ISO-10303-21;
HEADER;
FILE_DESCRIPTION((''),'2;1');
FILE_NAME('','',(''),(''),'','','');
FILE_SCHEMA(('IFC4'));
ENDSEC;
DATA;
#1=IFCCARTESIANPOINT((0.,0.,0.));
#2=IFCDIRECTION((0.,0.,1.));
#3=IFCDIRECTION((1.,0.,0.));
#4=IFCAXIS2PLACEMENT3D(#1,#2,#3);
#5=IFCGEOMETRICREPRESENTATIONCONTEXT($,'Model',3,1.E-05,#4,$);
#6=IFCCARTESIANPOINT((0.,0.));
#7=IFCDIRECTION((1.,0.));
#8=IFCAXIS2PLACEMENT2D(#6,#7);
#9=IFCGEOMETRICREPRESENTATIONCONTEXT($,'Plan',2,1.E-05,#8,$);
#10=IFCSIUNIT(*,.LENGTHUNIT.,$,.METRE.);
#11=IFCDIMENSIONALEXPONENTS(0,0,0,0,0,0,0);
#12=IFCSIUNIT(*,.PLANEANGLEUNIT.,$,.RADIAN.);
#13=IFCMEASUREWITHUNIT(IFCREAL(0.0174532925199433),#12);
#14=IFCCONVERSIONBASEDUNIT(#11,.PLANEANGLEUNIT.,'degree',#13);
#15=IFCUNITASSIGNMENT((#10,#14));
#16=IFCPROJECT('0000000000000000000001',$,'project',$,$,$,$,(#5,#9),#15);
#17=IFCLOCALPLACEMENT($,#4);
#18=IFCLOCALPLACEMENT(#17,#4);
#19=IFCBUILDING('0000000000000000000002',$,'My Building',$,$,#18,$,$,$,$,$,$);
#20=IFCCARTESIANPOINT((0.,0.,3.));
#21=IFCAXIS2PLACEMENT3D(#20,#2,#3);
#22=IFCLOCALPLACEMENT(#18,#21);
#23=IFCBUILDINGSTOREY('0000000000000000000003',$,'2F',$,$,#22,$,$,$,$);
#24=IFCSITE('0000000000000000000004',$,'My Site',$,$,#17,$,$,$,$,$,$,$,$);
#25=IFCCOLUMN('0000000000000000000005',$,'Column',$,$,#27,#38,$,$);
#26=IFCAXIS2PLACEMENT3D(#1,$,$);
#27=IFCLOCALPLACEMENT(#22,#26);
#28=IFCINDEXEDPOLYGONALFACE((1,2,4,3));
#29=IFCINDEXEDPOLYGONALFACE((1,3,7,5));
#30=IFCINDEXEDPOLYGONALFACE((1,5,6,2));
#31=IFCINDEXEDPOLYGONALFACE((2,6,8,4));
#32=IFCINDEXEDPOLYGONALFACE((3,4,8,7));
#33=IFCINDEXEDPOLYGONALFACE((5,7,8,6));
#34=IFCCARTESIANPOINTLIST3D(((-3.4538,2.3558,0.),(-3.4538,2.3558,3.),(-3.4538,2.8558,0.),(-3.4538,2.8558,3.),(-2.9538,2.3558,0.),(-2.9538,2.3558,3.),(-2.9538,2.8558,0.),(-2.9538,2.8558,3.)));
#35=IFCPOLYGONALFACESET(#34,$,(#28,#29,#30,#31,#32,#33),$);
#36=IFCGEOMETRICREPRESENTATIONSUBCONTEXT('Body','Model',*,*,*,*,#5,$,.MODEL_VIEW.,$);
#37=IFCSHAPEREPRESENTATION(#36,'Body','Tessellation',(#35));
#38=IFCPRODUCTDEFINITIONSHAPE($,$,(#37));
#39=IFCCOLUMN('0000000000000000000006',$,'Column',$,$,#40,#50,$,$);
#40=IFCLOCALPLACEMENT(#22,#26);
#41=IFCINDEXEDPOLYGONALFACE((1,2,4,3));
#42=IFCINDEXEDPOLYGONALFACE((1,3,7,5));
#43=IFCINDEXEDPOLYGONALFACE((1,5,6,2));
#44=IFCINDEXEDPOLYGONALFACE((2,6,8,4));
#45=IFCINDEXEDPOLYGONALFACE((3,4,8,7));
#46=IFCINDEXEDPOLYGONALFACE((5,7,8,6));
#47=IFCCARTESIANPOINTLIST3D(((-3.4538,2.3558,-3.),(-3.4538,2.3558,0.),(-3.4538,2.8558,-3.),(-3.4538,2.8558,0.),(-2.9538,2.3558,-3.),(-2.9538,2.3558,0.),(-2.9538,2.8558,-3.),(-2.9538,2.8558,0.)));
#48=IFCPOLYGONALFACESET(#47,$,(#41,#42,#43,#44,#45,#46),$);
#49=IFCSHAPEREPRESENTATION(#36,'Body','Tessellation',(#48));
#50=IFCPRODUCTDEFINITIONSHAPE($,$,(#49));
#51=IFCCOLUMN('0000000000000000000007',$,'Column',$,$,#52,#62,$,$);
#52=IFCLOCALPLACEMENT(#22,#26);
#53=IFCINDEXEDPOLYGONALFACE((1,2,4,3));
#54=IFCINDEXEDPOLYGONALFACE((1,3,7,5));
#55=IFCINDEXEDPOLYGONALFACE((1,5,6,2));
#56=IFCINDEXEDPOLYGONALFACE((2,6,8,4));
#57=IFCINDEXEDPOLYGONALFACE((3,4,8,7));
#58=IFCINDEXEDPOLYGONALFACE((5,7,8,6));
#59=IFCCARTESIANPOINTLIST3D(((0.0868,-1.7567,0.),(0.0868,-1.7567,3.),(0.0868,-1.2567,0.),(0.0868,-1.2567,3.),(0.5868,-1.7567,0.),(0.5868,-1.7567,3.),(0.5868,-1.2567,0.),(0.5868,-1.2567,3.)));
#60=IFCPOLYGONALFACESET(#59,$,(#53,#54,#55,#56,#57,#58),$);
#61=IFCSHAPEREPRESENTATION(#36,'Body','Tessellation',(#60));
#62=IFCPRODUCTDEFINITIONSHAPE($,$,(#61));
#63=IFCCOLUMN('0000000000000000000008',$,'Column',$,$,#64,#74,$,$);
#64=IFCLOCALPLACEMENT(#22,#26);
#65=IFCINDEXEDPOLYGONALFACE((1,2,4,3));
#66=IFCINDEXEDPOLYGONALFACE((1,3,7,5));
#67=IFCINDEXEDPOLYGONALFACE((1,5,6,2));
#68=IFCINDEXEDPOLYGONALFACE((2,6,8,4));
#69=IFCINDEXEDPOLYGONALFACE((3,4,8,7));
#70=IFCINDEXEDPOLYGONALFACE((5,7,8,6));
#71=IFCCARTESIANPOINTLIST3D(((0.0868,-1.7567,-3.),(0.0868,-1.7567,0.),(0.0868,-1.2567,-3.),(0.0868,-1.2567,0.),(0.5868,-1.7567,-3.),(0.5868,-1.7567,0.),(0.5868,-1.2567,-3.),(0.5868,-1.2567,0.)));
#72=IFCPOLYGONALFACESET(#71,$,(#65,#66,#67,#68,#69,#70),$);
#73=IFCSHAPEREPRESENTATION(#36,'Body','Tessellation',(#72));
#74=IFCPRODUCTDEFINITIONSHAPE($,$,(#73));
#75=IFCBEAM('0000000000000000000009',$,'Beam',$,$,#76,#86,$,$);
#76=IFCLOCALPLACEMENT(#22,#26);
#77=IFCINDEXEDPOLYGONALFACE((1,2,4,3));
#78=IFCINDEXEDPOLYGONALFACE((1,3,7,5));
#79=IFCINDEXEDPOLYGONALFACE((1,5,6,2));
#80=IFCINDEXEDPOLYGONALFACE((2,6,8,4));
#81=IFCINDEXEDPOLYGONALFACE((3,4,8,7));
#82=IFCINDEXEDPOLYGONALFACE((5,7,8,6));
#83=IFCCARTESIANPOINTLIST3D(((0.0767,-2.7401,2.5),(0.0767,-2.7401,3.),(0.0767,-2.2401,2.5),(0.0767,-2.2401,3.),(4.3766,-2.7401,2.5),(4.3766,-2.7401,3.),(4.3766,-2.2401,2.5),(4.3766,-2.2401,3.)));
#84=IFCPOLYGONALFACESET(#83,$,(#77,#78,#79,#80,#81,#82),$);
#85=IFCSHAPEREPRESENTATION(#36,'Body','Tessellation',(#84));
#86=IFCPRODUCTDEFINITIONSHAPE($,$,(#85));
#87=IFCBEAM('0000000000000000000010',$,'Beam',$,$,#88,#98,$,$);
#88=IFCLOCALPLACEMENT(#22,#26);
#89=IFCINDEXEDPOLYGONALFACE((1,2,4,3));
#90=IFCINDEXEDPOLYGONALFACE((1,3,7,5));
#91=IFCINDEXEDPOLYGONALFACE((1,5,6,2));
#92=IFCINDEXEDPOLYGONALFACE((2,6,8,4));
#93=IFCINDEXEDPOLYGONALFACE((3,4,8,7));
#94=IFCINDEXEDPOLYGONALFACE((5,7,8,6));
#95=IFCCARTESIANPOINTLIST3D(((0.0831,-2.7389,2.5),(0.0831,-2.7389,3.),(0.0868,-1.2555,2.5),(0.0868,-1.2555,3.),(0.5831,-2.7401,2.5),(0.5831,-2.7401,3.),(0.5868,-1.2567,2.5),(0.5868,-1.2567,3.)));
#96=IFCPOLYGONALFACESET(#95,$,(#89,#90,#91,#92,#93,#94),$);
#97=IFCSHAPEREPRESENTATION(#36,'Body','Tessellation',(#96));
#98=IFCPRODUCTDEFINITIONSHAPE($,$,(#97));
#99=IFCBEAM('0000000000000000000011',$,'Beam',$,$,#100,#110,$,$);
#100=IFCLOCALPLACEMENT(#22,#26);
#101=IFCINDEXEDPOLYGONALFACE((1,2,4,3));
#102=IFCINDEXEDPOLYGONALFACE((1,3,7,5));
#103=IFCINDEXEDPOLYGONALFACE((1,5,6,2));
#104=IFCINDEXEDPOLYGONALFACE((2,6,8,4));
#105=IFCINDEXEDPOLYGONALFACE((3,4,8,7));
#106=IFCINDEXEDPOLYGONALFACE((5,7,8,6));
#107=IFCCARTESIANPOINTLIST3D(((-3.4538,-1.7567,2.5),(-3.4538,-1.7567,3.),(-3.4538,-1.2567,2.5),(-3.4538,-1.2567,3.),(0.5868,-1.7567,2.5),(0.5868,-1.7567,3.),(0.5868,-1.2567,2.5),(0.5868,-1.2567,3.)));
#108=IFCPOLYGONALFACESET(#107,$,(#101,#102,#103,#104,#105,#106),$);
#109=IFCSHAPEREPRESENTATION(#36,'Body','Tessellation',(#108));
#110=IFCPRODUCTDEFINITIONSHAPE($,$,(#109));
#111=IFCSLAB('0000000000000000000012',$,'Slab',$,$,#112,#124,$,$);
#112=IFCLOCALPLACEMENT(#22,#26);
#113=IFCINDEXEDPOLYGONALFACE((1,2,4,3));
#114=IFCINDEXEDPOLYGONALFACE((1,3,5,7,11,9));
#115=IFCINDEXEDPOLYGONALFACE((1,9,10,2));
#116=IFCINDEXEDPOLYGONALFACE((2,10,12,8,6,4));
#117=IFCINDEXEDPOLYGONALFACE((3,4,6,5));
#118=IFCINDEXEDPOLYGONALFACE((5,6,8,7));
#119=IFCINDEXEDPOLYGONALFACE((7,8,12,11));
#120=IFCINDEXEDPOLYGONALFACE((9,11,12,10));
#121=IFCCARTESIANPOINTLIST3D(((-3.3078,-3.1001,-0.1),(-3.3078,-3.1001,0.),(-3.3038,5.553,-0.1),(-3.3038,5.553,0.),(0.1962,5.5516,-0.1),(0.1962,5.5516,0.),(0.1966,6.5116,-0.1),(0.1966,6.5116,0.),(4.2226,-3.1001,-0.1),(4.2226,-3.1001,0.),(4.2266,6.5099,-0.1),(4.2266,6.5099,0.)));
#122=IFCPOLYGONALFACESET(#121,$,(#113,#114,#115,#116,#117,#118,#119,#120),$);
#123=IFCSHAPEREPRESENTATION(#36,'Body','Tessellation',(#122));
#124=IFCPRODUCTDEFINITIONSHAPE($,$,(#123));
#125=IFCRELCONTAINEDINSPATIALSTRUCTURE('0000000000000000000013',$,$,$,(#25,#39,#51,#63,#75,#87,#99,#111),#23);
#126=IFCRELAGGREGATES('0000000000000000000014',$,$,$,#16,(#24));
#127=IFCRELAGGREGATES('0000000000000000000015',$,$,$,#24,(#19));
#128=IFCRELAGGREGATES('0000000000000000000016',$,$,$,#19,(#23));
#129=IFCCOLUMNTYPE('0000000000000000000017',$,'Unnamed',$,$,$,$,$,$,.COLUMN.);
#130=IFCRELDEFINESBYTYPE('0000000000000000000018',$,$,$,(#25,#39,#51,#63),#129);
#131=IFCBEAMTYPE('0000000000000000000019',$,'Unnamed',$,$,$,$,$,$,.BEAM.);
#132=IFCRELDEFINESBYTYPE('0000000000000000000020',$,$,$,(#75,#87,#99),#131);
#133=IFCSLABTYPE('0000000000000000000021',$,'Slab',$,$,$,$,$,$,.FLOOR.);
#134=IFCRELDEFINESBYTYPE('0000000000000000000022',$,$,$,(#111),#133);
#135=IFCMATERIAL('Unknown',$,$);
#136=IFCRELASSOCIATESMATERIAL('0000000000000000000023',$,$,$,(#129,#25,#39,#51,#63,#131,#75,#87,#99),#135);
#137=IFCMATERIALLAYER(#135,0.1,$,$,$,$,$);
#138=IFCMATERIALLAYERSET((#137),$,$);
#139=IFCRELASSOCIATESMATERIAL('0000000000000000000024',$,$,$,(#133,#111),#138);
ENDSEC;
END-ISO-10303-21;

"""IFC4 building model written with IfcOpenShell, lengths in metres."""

from ifc_helpers import new_model, entity, si_unit, converted_unit, frame, origin_with_axes, origin_2d_with_axis, place, context, subcontext, project, spatial, indexed_curve, rectangle, outline, extrude, material, layer, layer_set, layer_usage, material_profile, profile_set, profile_usage, type_object, element, save


model = new_model("IFC4")

# Units and contexts
model_context = context("Model", 3, precision=1e-05, world=origin_with_axes())
plan_context = context("Plan", 2, precision=1e-05, world=origin_2d_with_axis())
body_context_1 = subcontext(model_context, "Body", "Model", "MODEL_VIEW")
ifc_project = project(units=[si_unit("LENGTHUNIT", "METRE"), converted_unit("PLANEANGLEUNIT", "degree", entity("IfcReal", 0.0174532925199433), si_unit("PLANEANGLEUNIT", "RADIAN"), dimensions=[0, 0, 0, 0, 0, 0, 0])], contexts=[model_context, plan_context])

# Site, building, storey
site_placement = place(None, origin_with_axes())
site = spatial("IfcSite", under=ifc_project, at=site_placement, Name="My Site")
building_placement = place(site_placement, origin_with_axes())
building = spatial("IfcBuilding", under=site, at=building_placement, Name="My Building")
storey_placement = place(building_placement, frame((0.0, 0.0, 3.0), z_axis=(0.0, 0.0, 1.0), x_axis=(1.0, 0.0, 0.0)))
storey = spatial("IfcBuildingStorey", under=building, at=storey_placement, Name="2F")

# Columns
ifc_material = material(Name="Unknown")
ifc_material_profile_1 = material_profile(ifc_material, rectangle(XDim=0.5, YDim=0.5))
ifc_profile_set_1 = profile_set([ifc_material_profile_1])
ifc_profile_usage_1 = profile_usage(ifc_profile_set_1, cardinal=5)
column_type = type_object("IfcColumnType", Name="Unnamed", PredefinedType="COLUMN", material=ifc_profile_set_1)
column_1_placement = place(storey_placement, frame((-3.2038, 2.6058, 0.0), z_axis=(0.0, 0.0, 1.0), x_axis=(1.0, 0.0, 0.0)))
element("IfcColumn", 1, at=column_1_placement, inside=storey, type_object=column_type, material=ifc_profile_usage_1, Name="Column", context=body_context_1, shape_type="SweptSolid", body=[
    extrude(rectangle(XDim=0.5, YDim=0.5), origin_with_axes(), (0.0, 0.0, 1.0), 3.0),
])
ifc_profile_usage_2 = profile_usage(ifc_profile_set_1, cardinal=5)
column_2_placement = place(storey_placement, frame((-3.2038, 2.6058, -3.0), z_axis=(0.0, 0.0, 1.0), x_axis=(1.0, 0.0, 0.0)))
element("IfcColumn", 2, at=column_2_placement, inside=storey, type_object=column_type, material=ifc_profile_usage_2, Name="Column", context=body_context_1, shape_type="SweptSolid", body=[
    extrude(rectangle(XDim=0.5, YDim=0.5), origin_with_axes(), (0.0, 0.0, 1.0), 3.0),
])
ifc_profile_usage_3 = profile_usage(ifc_profile_set_1, cardinal=5)
column_3_placement = place(storey_placement, frame((0.3368, -1.5067, 0.0), z_axis=(0.0, 0.0, 1.0), x_axis=(1.0, 0.0, 0.0)))
element("IfcColumn", 3, at=column_3_placement, inside=storey, type_object=column_type, material=ifc_profile_usage_3, Name="Column", context=body_context_1, shape_type="SweptSolid", body=[
    extrude(rectangle(XDim=0.5, YDim=0.5), origin_with_axes(), (0.0, 0.0, 1.0), 3.0),
])
ifc_profile_usage_4 = profile_usage(ifc_profile_set_1, cardinal=5)
column_4_placement = place(storey_placement, frame((0.3368, -1.5067, -3.0), z_axis=(0.0, 0.0, 1.0), x_axis=(1.0, 0.0, 0.0)))
element("IfcColumn", 4, at=column_4_placement, inside=storey, type_object=column_type, material=ifc_profile_usage_4, Name="Column", context=body_context_1, shape_type="SweptSolid", body=[
    extrude(rectangle(XDim=0.5, YDim=0.5), origin_with_axes(), (0.0, 0.0, 1.0), 3.0),
])

# Beams
ifc_material_profile_2 = material_profile(ifc_material, rectangle(XDim=0.5, YDim=0.5))
ifc_profile_set_2 = profile_set([ifc_material_profile_2])
ifc_profile_usage_5 = profile_usage(ifc_profile_set_2, cardinal=7)
beam_type = type_object("IfcBeamType", Name="Unnamed", PredefinedType="BEAM", material=ifc_profile_set_2)
beam_1_placement = place(storey_placement, frame((0.0767, -2.2401, 3.0), z_axis=(1.0, 0.0, 0.0), x_axis=(0.0, 1.0, 0.0)))
element("IfcBeam", 5, at=beam_1_placement, inside=storey, type_object=beam_type, material=ifc_profile_usage_5, Name="Beam", context=body_context_1, shape_type="SweptSolid", body=[
    extrude(rectangle(XDim=0.5, YDim=0.5), frame((-0.25, -0.25, 0.0), z_axis=(0.0, 0.0, 1.0), x_axis=(1.0, 0.0, 0.0)), (0.0, 0.0, 1.0), 4.2999),
])
ifc_profile_usage_6 = profile_usage(ifc_profile_set_2, cardinal=7)
beam_2_placement = place(storey_placement, frame((0.5868, -1.2567, 3.0), z_axis=(-0.002444, -0.999997, 0.0), x_axis=(0.999997, -0.002444, 0.0)))
element("IfcBeam", 6, at=beam_2_placement, inside=storey, type_object=beam_type, material=ifc_profile_usage_6, Name="Beam", context=body_context_1, shape_type="SweptSolid", body=[
    extrude(rectangle(XDim=0.5, YDim=0.5), frame((-0.25, -0.25, 0.0), z_axis=(0.0, 0.0, 1.0), x_axis=(1.0, 0.0, 0.0)), (0.0, 0.0, 1.0), 1.4834),
])
ifc_profile_usage_7 = profile_usage(ifc_profile_set_2, cardinal=7)
beam_3_placement = place(storey_placement, frame((-3.4538, -1.2567, 3.0), z_axis=(1.0, 0.0, 0.0), x_axis=(0.0, 1.0, 0.0)))
element("IfcBeam", 7, at=beam_3_placement, inside=storey, type_object=beam_type, material=ifc_profile_usage_7, Name="Beam", context=body_context_1, shape_type="SweptSolid", body=[
    extrude(rectangle(XDim=0.5, YDim=0.5), frame((-0.25, -0.25, 0.0), z_axis=(0.0, 0.0, 1.0), x_axis=(1.0, 0.0, 0.0)), (0.0, 0.0, 1.0), 4.0406),
])

# Slab
ifc_layer_1 = layer(ifc_material, 0.1)
ifc_layer_set_1 = layer_set([ifc_layer_1])
ifc_layer_usage_1 = layer_usage(ifc_layer_set_1, "AXIS3", "POSITIVE", -0.1)
slab_type = type_object("IfcSlabType", Name="Slab", PredefinedType="FLOOR", material=ifc_layer_set_1)
slab_placement = place(storey_placement, frame((-3.3078, -3.1001, 0.0), z_axis=(0.0, 0.0, 1.0), x_axis=(1.0, 0.0, 0.0)))
element("IfcSlab", 8, at=slab_placement, inside=storey, type_object=slab_type, material=ifc_layer_usage_1, Name="Slab", context=body_context_1, shape_type="SweptSolid", body=[
    extrude(outline(indexed_curve([(0.0, 0.0), (7.5304, 0.0), (7.5344, 9.61), (3.5044, 9.6117), (3.504, 8.6517), (0.004, 8.6531), (0.0, 0.0)])), frame((0.0, 0.0, -0.1), z_axis=(0.0, 0.0, 1.0), x_axis=(1.0, 0.0, 0.0)), (0.0, 0.0, 1.0), 0.1),
])

save(model, "model.ifc")
